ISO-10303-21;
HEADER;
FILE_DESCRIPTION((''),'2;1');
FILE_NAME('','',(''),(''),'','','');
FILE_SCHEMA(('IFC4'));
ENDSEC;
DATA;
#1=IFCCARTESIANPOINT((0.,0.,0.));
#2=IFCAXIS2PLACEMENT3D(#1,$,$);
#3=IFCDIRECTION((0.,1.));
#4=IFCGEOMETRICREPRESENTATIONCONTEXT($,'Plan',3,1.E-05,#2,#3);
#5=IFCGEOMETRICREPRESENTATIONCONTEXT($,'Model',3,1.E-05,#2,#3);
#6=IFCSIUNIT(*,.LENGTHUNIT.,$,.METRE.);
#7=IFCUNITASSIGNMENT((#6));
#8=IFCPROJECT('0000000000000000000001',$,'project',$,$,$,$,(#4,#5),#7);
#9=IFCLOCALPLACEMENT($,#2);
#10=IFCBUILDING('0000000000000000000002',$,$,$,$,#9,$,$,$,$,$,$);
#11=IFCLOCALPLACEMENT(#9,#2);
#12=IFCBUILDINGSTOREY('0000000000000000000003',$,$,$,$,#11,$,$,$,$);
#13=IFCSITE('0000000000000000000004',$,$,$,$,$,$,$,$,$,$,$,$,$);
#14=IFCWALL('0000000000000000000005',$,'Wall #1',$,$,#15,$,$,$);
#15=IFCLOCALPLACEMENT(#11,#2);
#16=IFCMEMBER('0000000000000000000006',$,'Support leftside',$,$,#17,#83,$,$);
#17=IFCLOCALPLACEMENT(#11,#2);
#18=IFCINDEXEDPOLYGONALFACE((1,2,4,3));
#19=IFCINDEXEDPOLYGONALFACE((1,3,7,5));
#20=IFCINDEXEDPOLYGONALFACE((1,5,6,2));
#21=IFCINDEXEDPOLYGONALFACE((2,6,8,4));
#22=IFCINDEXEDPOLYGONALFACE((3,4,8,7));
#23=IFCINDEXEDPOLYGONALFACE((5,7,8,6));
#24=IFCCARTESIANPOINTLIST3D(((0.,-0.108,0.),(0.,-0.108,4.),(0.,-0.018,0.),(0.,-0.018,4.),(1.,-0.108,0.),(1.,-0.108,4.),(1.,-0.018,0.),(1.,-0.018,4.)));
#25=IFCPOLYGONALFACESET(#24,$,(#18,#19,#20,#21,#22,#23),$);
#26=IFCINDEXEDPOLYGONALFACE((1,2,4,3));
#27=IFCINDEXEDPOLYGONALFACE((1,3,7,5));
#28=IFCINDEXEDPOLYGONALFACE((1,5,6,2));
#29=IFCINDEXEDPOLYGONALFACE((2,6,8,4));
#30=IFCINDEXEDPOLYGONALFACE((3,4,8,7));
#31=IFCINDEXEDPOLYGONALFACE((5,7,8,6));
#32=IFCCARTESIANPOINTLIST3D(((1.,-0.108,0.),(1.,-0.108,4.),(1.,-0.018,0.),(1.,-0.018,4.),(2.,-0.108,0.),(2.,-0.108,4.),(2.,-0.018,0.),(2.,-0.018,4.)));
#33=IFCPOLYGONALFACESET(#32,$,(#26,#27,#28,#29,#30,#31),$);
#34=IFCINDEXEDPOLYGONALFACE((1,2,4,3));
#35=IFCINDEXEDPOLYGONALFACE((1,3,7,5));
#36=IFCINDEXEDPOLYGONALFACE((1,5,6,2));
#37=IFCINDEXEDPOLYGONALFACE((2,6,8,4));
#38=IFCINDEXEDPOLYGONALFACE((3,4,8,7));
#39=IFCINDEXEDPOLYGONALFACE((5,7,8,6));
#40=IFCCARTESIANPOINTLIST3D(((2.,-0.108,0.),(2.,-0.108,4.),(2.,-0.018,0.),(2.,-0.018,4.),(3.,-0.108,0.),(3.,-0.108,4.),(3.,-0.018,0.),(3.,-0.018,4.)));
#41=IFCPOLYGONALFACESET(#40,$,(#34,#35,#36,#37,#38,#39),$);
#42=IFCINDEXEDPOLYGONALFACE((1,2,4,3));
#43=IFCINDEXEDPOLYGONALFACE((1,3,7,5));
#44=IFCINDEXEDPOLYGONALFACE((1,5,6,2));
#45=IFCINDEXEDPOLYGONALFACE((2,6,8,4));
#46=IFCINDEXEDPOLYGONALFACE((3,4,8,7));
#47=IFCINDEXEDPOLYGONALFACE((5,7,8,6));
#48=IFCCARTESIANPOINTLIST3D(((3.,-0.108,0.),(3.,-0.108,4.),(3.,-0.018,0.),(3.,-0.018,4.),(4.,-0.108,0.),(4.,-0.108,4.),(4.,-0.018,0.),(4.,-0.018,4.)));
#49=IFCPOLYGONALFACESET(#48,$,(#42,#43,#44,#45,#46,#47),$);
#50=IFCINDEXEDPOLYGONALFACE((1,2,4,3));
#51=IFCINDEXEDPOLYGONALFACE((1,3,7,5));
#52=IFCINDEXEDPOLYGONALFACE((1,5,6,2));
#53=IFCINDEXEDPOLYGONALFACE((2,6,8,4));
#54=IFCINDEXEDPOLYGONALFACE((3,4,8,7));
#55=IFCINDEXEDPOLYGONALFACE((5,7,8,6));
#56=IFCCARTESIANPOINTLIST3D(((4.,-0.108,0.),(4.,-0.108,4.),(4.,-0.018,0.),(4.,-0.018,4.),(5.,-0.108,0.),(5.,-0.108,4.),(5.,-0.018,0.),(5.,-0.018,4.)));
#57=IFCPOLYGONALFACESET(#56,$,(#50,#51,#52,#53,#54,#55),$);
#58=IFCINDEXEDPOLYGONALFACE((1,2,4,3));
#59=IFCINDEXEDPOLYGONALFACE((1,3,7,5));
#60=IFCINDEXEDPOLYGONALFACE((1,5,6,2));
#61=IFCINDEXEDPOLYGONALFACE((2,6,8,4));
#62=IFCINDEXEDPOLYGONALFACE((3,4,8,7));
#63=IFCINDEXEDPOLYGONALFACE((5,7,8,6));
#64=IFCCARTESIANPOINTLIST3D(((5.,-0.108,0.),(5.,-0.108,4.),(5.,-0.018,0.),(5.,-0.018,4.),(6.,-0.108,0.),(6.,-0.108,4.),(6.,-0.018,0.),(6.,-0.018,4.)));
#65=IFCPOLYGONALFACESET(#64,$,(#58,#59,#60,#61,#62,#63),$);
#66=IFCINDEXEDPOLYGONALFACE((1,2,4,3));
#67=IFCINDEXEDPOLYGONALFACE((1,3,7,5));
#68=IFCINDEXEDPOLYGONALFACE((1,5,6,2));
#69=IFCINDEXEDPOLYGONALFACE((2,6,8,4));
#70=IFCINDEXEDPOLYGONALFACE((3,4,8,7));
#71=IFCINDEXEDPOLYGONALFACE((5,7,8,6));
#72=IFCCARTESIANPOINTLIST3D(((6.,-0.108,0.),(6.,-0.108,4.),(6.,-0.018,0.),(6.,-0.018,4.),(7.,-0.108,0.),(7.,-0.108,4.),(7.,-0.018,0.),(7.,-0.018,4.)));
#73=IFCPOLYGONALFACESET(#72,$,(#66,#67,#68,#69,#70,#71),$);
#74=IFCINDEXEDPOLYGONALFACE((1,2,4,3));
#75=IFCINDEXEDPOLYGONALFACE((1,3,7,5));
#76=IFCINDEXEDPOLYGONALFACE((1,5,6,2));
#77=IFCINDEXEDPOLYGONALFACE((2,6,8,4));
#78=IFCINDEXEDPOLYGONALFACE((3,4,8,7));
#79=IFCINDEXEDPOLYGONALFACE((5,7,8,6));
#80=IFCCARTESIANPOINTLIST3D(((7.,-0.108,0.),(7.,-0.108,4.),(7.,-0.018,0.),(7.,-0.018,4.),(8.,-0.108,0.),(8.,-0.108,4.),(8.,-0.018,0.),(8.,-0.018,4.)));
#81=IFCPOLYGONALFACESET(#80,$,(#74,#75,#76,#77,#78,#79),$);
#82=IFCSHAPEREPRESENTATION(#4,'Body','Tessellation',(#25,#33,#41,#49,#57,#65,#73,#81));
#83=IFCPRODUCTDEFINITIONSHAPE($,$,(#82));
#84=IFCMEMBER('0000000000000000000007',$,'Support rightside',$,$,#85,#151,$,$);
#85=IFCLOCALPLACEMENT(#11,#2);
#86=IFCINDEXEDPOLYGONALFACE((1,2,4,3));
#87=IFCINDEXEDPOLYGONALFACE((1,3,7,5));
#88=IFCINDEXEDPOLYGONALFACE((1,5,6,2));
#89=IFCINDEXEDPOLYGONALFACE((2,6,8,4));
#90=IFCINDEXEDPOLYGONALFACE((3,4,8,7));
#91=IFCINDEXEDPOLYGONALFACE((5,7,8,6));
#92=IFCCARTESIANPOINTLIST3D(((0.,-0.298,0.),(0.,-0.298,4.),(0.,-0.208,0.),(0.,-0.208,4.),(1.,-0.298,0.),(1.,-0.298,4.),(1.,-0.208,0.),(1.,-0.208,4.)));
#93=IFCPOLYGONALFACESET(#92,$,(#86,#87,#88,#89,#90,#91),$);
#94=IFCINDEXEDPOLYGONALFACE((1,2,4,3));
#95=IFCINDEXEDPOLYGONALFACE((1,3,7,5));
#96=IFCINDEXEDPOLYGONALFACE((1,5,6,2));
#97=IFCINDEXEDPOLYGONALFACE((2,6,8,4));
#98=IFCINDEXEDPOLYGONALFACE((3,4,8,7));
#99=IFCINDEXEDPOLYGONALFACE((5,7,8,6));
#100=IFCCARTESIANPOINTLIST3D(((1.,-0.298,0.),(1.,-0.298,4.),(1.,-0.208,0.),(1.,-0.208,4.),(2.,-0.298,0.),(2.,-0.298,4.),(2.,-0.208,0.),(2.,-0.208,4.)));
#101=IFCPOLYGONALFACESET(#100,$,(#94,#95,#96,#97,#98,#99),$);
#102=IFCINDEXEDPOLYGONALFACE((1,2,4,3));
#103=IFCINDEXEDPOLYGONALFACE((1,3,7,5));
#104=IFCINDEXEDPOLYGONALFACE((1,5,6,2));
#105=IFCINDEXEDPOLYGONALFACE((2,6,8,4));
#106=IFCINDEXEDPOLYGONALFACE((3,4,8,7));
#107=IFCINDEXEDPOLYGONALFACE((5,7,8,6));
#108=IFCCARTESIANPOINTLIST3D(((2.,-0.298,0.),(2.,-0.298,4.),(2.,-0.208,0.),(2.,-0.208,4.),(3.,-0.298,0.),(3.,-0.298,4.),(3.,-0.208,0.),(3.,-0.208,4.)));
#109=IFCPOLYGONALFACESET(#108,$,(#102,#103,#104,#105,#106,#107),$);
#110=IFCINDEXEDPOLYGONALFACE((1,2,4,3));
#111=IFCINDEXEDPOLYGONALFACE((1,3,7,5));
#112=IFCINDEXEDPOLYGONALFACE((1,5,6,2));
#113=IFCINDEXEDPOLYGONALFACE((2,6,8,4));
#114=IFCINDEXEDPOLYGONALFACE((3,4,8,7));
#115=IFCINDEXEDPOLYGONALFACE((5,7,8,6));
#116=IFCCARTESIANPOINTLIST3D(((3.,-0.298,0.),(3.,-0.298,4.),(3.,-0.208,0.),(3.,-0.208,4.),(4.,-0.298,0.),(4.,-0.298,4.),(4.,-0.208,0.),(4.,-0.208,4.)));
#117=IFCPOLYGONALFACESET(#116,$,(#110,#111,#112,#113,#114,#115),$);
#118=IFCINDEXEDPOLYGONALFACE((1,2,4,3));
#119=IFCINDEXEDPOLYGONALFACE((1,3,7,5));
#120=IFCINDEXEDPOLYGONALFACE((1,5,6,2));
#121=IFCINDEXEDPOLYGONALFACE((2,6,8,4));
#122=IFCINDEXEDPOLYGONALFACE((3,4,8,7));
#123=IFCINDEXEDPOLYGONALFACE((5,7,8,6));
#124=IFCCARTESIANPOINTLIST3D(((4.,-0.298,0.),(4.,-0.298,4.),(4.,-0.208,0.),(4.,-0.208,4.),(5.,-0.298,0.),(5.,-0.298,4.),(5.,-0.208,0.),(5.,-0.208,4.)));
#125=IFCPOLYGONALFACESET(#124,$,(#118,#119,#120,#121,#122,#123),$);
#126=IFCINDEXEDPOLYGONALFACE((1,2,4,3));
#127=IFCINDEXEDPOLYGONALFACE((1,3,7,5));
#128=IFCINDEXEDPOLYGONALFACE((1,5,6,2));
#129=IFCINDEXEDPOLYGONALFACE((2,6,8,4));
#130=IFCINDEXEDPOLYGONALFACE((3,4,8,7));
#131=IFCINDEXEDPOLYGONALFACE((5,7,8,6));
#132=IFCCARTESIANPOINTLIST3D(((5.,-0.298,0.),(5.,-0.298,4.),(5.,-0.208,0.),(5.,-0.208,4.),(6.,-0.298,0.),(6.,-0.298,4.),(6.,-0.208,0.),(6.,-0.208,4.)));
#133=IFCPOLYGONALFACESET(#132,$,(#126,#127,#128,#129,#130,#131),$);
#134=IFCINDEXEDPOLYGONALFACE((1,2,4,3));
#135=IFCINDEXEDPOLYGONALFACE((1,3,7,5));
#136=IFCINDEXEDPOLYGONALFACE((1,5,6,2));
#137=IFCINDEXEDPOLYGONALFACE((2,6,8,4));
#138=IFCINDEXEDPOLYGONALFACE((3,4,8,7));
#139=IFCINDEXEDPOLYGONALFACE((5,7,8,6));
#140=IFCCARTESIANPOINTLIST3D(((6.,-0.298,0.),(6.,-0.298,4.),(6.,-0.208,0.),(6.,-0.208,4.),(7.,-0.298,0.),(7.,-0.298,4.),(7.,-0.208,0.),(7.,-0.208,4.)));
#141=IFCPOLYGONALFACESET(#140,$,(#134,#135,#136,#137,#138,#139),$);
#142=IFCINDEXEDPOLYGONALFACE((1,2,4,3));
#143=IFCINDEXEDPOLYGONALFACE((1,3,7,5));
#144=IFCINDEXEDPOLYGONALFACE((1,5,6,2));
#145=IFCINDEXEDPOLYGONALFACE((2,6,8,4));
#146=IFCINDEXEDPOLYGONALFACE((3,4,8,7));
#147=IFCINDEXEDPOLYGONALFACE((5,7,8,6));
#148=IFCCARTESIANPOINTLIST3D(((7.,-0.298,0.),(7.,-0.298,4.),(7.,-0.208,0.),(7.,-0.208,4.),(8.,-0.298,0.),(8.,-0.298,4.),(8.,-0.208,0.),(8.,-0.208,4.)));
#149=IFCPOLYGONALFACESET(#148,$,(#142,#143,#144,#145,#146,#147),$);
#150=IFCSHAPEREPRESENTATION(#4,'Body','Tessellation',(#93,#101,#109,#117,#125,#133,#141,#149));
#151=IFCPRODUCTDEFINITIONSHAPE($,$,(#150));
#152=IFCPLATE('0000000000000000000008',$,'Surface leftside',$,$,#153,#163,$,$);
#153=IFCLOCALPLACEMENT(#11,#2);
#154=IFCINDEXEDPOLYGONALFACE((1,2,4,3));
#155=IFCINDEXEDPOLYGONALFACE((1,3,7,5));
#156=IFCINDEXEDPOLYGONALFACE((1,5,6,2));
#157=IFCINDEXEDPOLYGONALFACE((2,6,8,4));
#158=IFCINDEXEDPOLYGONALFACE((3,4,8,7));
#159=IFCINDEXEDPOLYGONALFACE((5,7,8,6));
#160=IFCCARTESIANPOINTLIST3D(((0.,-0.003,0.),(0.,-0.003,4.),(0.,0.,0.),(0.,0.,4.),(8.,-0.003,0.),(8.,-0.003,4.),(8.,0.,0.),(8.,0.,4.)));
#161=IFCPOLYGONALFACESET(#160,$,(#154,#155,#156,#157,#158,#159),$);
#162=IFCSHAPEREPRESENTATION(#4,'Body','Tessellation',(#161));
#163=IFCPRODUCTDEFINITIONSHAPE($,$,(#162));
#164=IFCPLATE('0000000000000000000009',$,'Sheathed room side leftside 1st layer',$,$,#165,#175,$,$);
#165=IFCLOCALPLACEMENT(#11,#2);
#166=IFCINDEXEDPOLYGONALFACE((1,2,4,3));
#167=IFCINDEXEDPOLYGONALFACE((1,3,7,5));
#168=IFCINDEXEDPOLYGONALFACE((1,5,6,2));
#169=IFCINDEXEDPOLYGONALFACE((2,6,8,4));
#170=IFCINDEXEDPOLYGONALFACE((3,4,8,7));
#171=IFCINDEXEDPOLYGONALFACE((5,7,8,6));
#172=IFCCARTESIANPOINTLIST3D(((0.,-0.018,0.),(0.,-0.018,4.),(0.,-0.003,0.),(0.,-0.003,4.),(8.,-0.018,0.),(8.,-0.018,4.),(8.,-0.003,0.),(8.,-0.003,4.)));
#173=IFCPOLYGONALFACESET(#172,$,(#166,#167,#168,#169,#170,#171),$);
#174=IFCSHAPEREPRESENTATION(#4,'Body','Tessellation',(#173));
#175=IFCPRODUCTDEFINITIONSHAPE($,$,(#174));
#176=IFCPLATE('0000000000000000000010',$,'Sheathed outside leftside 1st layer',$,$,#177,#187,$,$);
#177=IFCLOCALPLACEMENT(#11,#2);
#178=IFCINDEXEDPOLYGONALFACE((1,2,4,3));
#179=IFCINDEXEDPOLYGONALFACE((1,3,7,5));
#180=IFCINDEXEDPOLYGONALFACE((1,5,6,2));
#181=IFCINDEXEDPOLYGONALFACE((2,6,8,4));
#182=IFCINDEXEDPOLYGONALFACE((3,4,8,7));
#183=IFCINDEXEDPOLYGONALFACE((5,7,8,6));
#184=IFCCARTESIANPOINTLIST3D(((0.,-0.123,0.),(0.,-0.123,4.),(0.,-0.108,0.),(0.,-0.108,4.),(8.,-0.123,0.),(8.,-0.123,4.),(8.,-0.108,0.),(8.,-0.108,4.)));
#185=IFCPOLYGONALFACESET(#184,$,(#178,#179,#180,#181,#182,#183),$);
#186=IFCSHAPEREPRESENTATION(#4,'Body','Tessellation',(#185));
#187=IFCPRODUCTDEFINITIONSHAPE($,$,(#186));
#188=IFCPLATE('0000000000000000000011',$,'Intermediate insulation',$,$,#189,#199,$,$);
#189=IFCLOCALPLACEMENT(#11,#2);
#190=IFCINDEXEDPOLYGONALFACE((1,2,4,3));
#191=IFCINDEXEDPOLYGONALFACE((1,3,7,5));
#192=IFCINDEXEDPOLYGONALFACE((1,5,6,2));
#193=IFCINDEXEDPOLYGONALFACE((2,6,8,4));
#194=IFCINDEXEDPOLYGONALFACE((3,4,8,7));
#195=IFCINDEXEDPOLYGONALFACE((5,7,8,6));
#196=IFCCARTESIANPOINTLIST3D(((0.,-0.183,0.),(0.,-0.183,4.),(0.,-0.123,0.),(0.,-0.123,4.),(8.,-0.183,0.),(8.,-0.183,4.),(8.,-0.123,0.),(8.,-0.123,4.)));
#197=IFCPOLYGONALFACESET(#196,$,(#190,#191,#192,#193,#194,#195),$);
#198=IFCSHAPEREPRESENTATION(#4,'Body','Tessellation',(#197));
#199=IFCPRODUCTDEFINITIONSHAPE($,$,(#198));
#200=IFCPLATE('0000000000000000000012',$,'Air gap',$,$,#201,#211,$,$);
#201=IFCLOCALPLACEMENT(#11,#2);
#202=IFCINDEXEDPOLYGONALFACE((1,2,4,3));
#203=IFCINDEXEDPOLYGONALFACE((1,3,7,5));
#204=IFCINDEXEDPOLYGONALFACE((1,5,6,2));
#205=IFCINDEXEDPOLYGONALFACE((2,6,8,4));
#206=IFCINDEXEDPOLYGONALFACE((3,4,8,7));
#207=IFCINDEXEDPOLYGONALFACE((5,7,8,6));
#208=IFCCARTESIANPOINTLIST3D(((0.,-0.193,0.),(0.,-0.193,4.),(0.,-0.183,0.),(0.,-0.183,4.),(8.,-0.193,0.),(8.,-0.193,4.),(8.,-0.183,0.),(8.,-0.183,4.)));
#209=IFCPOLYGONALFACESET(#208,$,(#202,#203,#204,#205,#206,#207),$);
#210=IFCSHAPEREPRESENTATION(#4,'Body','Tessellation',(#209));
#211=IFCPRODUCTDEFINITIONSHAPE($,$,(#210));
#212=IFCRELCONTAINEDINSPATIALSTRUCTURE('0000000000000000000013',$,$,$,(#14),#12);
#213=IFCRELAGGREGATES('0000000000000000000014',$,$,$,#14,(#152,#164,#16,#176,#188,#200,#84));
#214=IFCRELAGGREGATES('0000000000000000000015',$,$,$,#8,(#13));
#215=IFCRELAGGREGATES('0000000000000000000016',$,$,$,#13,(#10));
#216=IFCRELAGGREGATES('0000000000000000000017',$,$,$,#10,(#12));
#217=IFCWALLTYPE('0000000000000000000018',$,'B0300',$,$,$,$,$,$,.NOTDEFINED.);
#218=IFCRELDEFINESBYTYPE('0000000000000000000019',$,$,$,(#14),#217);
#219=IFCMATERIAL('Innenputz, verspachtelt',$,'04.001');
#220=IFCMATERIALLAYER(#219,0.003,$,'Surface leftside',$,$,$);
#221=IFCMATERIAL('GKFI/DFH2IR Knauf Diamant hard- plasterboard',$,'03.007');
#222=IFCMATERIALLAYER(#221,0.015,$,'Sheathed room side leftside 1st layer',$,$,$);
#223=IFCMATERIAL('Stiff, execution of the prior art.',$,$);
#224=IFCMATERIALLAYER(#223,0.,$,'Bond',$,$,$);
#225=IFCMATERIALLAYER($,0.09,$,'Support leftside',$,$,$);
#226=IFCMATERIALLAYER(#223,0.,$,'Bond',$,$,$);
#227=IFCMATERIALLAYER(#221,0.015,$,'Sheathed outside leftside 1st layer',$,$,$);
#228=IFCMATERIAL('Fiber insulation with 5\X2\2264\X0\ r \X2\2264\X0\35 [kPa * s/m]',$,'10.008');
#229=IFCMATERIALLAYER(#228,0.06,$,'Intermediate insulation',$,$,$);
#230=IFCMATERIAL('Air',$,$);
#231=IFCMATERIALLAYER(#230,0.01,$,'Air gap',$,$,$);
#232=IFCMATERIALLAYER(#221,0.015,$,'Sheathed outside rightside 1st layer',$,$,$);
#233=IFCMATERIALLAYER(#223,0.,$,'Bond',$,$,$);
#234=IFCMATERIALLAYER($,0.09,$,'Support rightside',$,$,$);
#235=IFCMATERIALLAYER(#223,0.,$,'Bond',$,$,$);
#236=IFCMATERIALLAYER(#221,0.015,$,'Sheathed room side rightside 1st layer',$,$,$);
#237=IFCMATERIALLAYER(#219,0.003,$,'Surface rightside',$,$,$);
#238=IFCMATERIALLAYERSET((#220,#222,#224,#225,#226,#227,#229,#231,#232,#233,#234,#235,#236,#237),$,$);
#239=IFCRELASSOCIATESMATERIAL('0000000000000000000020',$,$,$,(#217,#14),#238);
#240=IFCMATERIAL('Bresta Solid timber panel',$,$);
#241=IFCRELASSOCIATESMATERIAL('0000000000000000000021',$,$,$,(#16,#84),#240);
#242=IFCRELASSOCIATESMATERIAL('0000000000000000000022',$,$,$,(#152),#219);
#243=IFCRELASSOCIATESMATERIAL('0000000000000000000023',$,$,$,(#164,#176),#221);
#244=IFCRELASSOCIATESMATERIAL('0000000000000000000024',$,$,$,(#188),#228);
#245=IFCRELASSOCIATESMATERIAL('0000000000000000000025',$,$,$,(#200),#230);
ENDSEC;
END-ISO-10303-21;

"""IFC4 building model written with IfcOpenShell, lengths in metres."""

from ifc_helpers import new_model, si_unit, direction, frame, frame_2d, origin, origin_with_axes, place, context, project, spatial, rectangle, extrude, material, layer, layer_set, type_object, element, aggregate, save


model = new_model("IFC4")

# Units and contexts
plan_context = context("Plan", 3, precision=1e-05, world=origin(), true_north=direction((0.0, 1.0)))
model_context = context("Model", 3, precision=1e-05, world=origin(), true_north=direction((0.0, 1.0)))
ifc_project = project(units=[si_unit("LENGTHUNIT", "METRE")], contexts=[plan_context, model_context])

# Site, building, storey
site = spatial("IfcSite", under=ifc_project)
building_placement = place(None, origin())
building = spatial("IfcBuilding", under=site, at=building_placement)
storey_placement = place(building_placement, origin())
storey = spatial("IfcBuildingStorey", under=building, at=storey_placement)

# Wall, members, plates
ifc_material_1 = material(Name="Innenputz, verspachtelt", Category="04.001")
ifc_layer_1 = layer(ifc_material_1, 0.003, Name="Surface leftside")
ifc_material_2 = material(Name="GKFI/DFH2IR Knauf Diamant hard- plasterboard", Category="03.007")
ifc_layer_2 = layer(ifc_material_2, 0.015, Name="Sheathed room side leftside 1st layer")
ifc_material_3 = material(Name="Stiff, execution of the prior art.")
ifc_layer_3 = layer(ifc_material_3, 0.0, Name="Bond")
ifc_layer_4 = layer(None, 0.09, Name="Support leftside")
ifc_layer_5 = layer(ifc_material_3, 0.0, Name="Bond")
ifc_layer_6 = layer(ifc_material_2, 0.015, Name="Sheathed outside leftside 1st layer")
ifc_material_4 = material(Name="Fiber insulation with 5≤ r ≤35 [kPa * s/m]", Category="10.008")
ifc_layer_7 = layer(ifc_material_4, 0.06, Name="Intermediate insulation")
ifc_material_5 = material(Name="Air")
ifc_layer_8 = layer(ifc_material_5, 0.01, Name="Air gap")
ifc_layer_9 = layer(ifc_material_2, 0.015, Name="Sheathed outside rightside 1st layer")
ifc_layer_10 = layer(ifc_material_3, 0.0, Name="Bond")
ifc_layer_11 = layer(None, 0.09, Name="Support rightside")
ifc_layer_12 = layer(ifc_material_3, 0.0, Name="Bond")
ifc_layer_13 = layer(ifc_material_2, 0.015, Name="Sheathed room side rightside 1st layer")
ifc_layer_14 = layer(ifc_material_1, 0.003, Name="Surface rightside")
ifc_layer_set = layer_set([ifc_layer_1, ifc_layer_2, ifc_layer_3, ifc_layer_4, ifc_layer_5, ifc_layer_6, ifc_layer_7, ifc_layer_8, ifc_layer_9, ifc_layer_10, ifc_layer_11, ifc_layer_12, ifc_layer_13, ifc_layer_14])
wall_type = type_object("IfcWallType", Name="B0300", PredefinedType="NOTDEFINED", material=ifc_layer_set)
wall_placement = place(None, frame((0.0, 0.0, 0.0), z_axis=(0.0, -1.0, 0.0), x_axis=(1.0, 0.0, 0.0)))
wall = element("IfcWall", 1, at=wall_placement, inside=storey, type_object=wall_type, material=ifc_layer_set, Name="Wall #1")
ifc_material_6 = material(Name="Bresta Solid timber panel")
member_1_placement = place(wall_placement, origin())
member_1 = element("IfcMember", 2, at=member_1_placement, material=ifc_material_6, Name="Support leftside", context=plan_context, shape_type="SweptSolid", body=[
    extrude(rectangle(XDim=1.0, YDim=0.09, at=frame_2d((0.5, 0.045), x_axis=(1.0, 0.0))), frame((0.0, 4.0, 0.018), z_axis=(0.0, -1.0, 0.0), x_axis=(1.0, 0.0, 0.0)), (0.0, 0.0, 1.0), 4.0),
    extrude(rectangle(XDim=1.0, YDim=0.09, at=frame_2d((0.5, 0.045), x_axis=(1.0, 0.0))), frame((1.0, 4.0, 0.018), z_axis=(0.0, -1.0, 0.0), x_axis=(1.0, 0.0, 0.0)), (0.0, 0.0, 1.0), 4.0),
    extrude(rectangle(XDim=1.0, YDim=0.09, at=frame_2d((0.5, 0.045), x_axis=(1.0, 0.0))), frame((2.0, 4.0, 0.018), z_axis=(0.0, -1.0, 0.0), x_axis=(1.0, 0.0, 0.0)), (0.0, 0.0, 1.0), 4.0),
    extrude(rectangle(XDim=1.0, YDim=0.09, at=frame_2d((0.5, 0.045), x_axis=(1.0, 0.0))), frame((3.0, 4.0, 0.018), z_axis=(0.0, -1.0, 0.0), x_axis=(1.0, 0.0, 0.0)), (0.0, 0.0, 1.0), 4.0),
    extrude(rectangle(XDim=1.0, YDim=0.09, at=frame_2d((0.5, 0.045), x_axis=(1.0, 0.0))), frame((4.0, 4.0, 0.018), z_axis=(0.0, -1.0, 0.0), x_axis=(1.0, 0.0, 0.0)), (0.0, 0.0, 1.0), 4.0),
    extrude(rectangle(XDim=1.0, YDim=0.09, at=frame_2d((0.5, 0.045), x_axis=(1.0, 0.0))), frame((5.0, 4.0, 0.018), z_axis=(0.0, -1.0, 0.0), x_axis=(1.0, 0.0, 0.0)), (0.0, 0.0, 1.0), 4.0),
    extrude(rectangle(XDim=1.0, YDim=0.09, at=frame_2d((0.5, 0.045), x_axis=(1.0, 0.0))), frame((6.0, 4.0, 0.018), z_axis=(0.0, -1.0, 0.0), x_axis=(1.0, 0.0, 0.0)), (0.0, 0.0, 1.0), 4.0),
    extrude(rectangle(XDim=1.0, YDim=0.09, at=frame_2d((0.5, 0.045), x_axis=(1.0, 0.0))), frame((7.0, 4.0, 0.018), z_axis=(0.0, -1.0, 0.0), x_axis=(1.0, 0.0, 0.0)), (0.0, 0.0, 1.0), 4.0),
])
member_2_placement = place(wall_placement, origin())
member_2 = element("IfcMember", 3, at=member_2_placement, material=ifc_material_6, Name="Support rightside", context=plan_context, shape_type="SweptSolid", body=[
    extrude(rectangle(XDim=1.0, YDim=0.09, at=frame_2d((0.5, 0.045), x_axis=(1.0, 0.0))), frame((0.0, 4.0, 0.208), z_axis=(0.0, -1.0, 0.0), x_axis=(1.0, 0.0, 0.0)), (0.0, 0.0, 1.0), 4.0),
    extrude(rectangle(XDim=1.0, YDim=0.09, at=frame_2d((0.5, 0.045), x_axis=(1.0, 0.0))), frame((1.0, 4.0, 0.208), z_axis=(0.0, -1.0, 0.0), x_axis=(1.0, 0.0, 0.0)), (0.0, 0.0, 1.0), 4.0),
    extrude(rectangle(XDim=1.0, YDim=0.09, at=frame_2d((0.5, 0.045), x_axis=(1.0, 0.0))), frame((2.0, 4.0, 0.208), z_axis=(0.0, -1.0, 0.0), x_axis=(1.0, 0.0, 0.0)), (0.0, 0.0, 1.0), 4.0),
    extrude(rectangle(XDim=1.0, YDim=0.09, at=frame_2d((0.5, 0.045), x_axis=(1.0, 0.0))), frame((3.0, 4.0, 0.208), z_axis=(0.0, -1.0, 0.0), x_axis=(1.0, 0.0, 0.0)), (0.0, 0.0, 1.0), 4.0),
    extrude(rectangle(XDim=1.0, YDim=0.09, at=frame_2d((0.5, 0.045), x_axis=(1.0, 0.0))), frame((4.0, 4.0, 0.208), z_axis=(0.0, -1.0, 0.0), x_axis=(1.0, 0.0, 0.0)), (0.0, 0.0, 1.0), 4.0),
    extrude(rectangle(XDim=1.0, YDim=0.09, at=frame_2d((0.5, 0.045), x_axis=(1.0, 0.0))), frame((5.0, 4.0, 0.208), z_axis=(0.0, -1.0, 0.0), x_axis=(1.0, 0.0, 0.0)), (0.0, 0.0, 1.0), 4.0),
    extrude(rectangle(XDim=1.0, YDim=0.09, at=frame_2d((0.5, 0.045), x_axis=(1.0, 0.0))), frame((6.0, 4.0, 0.208), z_axis=(0.0, -1.0, 0.0), x_axis=(1.0, 0.0, 0.0)), (0.0, 0.0, 1.0), 4.0),
    extrude(rectangle(XDim=1.0, YDim=0.09, at=frame_2d((0.5, 0.045), x_axis=(1.0, 0.0))), frame((7.0, 4.0, 0.208), z_axis=(0.0, -1.0, 0.0), x_axis=(1.0, 0.0, 0.0)), (0.0, 0.0, 1.0), 4.0),
])
plate_1_placement = place(wall_placement, origin())
plate_1 = element("IfcPlate", 4, at=plate_1_placement, material=ifc_material_1, Name="Surface leftside", context=plan_context, shape_type="SweptSolid", body=[
    extrude(rectangle(XDim=8.0, YDim=4.0, at=frame_2d((4.0, 2.0), x_axis=(1.0, 0.0))), origin_with_axes(), (0.0, 0.0, 1.0), 0.003),
])
plate_2_placement = place(wall_placement, origin())
plate_2 = element("IfcPlate", 5, at=plate_2_placement, material=ifc_material_2, Name="Sheathed room side leftside 1st layer", context=plan_context, shape_type="SweptSolid", body=[
    extrude(rectangle(XDim=8.0, YDim=4.0, at=frame_2d((4.0, 2.0), x_axis=(1.0, 0.0))), frame((0.0, 0.0, 0.003), z_axis=(0.0, 0.0, 1.0), x_axis=(1.0, 0.0, 0.0)), (0.0, 0.0, 1.0), 0.015),
])
plate_3_placement = place(wall_placement, origin())
plate_3 = element("IfcPlate", 6, at=plate_3_placement, material=ifc_material_2, Name="Sheathed outside leftside 1st layer", context=plan_context, shape_type="SweptSolid", body=[
    extrude(rectangle(XDim=8.0, YDim=4.0, at=frame_2d((4.0, 2.0), x_axis=(1.0, 0.0))), frame((0.0, 0.0, 0.108), z_axis=(0.0, 0.0, 1.0), x_axis=(1.0, 0.0, 0.0)), (0.0, 0.0, 1.0), 0.015),
])
plate_4_placement = place(wall_placement, origin())
plate_4 = element("IfcPlate", 7, at=plate_4_placement, material=ifc_material_4, Name="Intermediate insulation", context=plan_context, shape_type="SweptSolid", body=[
    extrude(rectangle(XDim=8.0, YDim=4.0, at=frame_2d((4.0, 2.0), x_axis=(1.0, 0.0))), frame((0.0, 0.0, 0.123), z_axis=(0.0, 0.0, 1.0), x_axis=(1.0, 0.0, 0.0)), (0.0, 0.0, 1.0), 0.06),
])
plate_5_placement = place(wall_placement, origin())
plate_5 = element("IfcPlate", 8, at=plate_5_placement, material=ifc_material_5, Name="Air gap", context=plan_context, shape_type="SweptSolid", body=[
    extrude(rectangle(XDim=8.0, YDim=4.0, at=frame_2d((4.0, 2.0), x_axis=(1.0, 0.0))), frame((0.0, 0.0, 0.183), z_axis=(0.0, 0.0, 1.0), x_axis=(1.0, 0.0, 0.0)), (0.0, 0.0, 1.0), 0.01),
])
aggregate(wall, [plate_1, plate_2, member_1, plate_3, plate_4, plate_5, member_2])

save(model, "model.ifc")
